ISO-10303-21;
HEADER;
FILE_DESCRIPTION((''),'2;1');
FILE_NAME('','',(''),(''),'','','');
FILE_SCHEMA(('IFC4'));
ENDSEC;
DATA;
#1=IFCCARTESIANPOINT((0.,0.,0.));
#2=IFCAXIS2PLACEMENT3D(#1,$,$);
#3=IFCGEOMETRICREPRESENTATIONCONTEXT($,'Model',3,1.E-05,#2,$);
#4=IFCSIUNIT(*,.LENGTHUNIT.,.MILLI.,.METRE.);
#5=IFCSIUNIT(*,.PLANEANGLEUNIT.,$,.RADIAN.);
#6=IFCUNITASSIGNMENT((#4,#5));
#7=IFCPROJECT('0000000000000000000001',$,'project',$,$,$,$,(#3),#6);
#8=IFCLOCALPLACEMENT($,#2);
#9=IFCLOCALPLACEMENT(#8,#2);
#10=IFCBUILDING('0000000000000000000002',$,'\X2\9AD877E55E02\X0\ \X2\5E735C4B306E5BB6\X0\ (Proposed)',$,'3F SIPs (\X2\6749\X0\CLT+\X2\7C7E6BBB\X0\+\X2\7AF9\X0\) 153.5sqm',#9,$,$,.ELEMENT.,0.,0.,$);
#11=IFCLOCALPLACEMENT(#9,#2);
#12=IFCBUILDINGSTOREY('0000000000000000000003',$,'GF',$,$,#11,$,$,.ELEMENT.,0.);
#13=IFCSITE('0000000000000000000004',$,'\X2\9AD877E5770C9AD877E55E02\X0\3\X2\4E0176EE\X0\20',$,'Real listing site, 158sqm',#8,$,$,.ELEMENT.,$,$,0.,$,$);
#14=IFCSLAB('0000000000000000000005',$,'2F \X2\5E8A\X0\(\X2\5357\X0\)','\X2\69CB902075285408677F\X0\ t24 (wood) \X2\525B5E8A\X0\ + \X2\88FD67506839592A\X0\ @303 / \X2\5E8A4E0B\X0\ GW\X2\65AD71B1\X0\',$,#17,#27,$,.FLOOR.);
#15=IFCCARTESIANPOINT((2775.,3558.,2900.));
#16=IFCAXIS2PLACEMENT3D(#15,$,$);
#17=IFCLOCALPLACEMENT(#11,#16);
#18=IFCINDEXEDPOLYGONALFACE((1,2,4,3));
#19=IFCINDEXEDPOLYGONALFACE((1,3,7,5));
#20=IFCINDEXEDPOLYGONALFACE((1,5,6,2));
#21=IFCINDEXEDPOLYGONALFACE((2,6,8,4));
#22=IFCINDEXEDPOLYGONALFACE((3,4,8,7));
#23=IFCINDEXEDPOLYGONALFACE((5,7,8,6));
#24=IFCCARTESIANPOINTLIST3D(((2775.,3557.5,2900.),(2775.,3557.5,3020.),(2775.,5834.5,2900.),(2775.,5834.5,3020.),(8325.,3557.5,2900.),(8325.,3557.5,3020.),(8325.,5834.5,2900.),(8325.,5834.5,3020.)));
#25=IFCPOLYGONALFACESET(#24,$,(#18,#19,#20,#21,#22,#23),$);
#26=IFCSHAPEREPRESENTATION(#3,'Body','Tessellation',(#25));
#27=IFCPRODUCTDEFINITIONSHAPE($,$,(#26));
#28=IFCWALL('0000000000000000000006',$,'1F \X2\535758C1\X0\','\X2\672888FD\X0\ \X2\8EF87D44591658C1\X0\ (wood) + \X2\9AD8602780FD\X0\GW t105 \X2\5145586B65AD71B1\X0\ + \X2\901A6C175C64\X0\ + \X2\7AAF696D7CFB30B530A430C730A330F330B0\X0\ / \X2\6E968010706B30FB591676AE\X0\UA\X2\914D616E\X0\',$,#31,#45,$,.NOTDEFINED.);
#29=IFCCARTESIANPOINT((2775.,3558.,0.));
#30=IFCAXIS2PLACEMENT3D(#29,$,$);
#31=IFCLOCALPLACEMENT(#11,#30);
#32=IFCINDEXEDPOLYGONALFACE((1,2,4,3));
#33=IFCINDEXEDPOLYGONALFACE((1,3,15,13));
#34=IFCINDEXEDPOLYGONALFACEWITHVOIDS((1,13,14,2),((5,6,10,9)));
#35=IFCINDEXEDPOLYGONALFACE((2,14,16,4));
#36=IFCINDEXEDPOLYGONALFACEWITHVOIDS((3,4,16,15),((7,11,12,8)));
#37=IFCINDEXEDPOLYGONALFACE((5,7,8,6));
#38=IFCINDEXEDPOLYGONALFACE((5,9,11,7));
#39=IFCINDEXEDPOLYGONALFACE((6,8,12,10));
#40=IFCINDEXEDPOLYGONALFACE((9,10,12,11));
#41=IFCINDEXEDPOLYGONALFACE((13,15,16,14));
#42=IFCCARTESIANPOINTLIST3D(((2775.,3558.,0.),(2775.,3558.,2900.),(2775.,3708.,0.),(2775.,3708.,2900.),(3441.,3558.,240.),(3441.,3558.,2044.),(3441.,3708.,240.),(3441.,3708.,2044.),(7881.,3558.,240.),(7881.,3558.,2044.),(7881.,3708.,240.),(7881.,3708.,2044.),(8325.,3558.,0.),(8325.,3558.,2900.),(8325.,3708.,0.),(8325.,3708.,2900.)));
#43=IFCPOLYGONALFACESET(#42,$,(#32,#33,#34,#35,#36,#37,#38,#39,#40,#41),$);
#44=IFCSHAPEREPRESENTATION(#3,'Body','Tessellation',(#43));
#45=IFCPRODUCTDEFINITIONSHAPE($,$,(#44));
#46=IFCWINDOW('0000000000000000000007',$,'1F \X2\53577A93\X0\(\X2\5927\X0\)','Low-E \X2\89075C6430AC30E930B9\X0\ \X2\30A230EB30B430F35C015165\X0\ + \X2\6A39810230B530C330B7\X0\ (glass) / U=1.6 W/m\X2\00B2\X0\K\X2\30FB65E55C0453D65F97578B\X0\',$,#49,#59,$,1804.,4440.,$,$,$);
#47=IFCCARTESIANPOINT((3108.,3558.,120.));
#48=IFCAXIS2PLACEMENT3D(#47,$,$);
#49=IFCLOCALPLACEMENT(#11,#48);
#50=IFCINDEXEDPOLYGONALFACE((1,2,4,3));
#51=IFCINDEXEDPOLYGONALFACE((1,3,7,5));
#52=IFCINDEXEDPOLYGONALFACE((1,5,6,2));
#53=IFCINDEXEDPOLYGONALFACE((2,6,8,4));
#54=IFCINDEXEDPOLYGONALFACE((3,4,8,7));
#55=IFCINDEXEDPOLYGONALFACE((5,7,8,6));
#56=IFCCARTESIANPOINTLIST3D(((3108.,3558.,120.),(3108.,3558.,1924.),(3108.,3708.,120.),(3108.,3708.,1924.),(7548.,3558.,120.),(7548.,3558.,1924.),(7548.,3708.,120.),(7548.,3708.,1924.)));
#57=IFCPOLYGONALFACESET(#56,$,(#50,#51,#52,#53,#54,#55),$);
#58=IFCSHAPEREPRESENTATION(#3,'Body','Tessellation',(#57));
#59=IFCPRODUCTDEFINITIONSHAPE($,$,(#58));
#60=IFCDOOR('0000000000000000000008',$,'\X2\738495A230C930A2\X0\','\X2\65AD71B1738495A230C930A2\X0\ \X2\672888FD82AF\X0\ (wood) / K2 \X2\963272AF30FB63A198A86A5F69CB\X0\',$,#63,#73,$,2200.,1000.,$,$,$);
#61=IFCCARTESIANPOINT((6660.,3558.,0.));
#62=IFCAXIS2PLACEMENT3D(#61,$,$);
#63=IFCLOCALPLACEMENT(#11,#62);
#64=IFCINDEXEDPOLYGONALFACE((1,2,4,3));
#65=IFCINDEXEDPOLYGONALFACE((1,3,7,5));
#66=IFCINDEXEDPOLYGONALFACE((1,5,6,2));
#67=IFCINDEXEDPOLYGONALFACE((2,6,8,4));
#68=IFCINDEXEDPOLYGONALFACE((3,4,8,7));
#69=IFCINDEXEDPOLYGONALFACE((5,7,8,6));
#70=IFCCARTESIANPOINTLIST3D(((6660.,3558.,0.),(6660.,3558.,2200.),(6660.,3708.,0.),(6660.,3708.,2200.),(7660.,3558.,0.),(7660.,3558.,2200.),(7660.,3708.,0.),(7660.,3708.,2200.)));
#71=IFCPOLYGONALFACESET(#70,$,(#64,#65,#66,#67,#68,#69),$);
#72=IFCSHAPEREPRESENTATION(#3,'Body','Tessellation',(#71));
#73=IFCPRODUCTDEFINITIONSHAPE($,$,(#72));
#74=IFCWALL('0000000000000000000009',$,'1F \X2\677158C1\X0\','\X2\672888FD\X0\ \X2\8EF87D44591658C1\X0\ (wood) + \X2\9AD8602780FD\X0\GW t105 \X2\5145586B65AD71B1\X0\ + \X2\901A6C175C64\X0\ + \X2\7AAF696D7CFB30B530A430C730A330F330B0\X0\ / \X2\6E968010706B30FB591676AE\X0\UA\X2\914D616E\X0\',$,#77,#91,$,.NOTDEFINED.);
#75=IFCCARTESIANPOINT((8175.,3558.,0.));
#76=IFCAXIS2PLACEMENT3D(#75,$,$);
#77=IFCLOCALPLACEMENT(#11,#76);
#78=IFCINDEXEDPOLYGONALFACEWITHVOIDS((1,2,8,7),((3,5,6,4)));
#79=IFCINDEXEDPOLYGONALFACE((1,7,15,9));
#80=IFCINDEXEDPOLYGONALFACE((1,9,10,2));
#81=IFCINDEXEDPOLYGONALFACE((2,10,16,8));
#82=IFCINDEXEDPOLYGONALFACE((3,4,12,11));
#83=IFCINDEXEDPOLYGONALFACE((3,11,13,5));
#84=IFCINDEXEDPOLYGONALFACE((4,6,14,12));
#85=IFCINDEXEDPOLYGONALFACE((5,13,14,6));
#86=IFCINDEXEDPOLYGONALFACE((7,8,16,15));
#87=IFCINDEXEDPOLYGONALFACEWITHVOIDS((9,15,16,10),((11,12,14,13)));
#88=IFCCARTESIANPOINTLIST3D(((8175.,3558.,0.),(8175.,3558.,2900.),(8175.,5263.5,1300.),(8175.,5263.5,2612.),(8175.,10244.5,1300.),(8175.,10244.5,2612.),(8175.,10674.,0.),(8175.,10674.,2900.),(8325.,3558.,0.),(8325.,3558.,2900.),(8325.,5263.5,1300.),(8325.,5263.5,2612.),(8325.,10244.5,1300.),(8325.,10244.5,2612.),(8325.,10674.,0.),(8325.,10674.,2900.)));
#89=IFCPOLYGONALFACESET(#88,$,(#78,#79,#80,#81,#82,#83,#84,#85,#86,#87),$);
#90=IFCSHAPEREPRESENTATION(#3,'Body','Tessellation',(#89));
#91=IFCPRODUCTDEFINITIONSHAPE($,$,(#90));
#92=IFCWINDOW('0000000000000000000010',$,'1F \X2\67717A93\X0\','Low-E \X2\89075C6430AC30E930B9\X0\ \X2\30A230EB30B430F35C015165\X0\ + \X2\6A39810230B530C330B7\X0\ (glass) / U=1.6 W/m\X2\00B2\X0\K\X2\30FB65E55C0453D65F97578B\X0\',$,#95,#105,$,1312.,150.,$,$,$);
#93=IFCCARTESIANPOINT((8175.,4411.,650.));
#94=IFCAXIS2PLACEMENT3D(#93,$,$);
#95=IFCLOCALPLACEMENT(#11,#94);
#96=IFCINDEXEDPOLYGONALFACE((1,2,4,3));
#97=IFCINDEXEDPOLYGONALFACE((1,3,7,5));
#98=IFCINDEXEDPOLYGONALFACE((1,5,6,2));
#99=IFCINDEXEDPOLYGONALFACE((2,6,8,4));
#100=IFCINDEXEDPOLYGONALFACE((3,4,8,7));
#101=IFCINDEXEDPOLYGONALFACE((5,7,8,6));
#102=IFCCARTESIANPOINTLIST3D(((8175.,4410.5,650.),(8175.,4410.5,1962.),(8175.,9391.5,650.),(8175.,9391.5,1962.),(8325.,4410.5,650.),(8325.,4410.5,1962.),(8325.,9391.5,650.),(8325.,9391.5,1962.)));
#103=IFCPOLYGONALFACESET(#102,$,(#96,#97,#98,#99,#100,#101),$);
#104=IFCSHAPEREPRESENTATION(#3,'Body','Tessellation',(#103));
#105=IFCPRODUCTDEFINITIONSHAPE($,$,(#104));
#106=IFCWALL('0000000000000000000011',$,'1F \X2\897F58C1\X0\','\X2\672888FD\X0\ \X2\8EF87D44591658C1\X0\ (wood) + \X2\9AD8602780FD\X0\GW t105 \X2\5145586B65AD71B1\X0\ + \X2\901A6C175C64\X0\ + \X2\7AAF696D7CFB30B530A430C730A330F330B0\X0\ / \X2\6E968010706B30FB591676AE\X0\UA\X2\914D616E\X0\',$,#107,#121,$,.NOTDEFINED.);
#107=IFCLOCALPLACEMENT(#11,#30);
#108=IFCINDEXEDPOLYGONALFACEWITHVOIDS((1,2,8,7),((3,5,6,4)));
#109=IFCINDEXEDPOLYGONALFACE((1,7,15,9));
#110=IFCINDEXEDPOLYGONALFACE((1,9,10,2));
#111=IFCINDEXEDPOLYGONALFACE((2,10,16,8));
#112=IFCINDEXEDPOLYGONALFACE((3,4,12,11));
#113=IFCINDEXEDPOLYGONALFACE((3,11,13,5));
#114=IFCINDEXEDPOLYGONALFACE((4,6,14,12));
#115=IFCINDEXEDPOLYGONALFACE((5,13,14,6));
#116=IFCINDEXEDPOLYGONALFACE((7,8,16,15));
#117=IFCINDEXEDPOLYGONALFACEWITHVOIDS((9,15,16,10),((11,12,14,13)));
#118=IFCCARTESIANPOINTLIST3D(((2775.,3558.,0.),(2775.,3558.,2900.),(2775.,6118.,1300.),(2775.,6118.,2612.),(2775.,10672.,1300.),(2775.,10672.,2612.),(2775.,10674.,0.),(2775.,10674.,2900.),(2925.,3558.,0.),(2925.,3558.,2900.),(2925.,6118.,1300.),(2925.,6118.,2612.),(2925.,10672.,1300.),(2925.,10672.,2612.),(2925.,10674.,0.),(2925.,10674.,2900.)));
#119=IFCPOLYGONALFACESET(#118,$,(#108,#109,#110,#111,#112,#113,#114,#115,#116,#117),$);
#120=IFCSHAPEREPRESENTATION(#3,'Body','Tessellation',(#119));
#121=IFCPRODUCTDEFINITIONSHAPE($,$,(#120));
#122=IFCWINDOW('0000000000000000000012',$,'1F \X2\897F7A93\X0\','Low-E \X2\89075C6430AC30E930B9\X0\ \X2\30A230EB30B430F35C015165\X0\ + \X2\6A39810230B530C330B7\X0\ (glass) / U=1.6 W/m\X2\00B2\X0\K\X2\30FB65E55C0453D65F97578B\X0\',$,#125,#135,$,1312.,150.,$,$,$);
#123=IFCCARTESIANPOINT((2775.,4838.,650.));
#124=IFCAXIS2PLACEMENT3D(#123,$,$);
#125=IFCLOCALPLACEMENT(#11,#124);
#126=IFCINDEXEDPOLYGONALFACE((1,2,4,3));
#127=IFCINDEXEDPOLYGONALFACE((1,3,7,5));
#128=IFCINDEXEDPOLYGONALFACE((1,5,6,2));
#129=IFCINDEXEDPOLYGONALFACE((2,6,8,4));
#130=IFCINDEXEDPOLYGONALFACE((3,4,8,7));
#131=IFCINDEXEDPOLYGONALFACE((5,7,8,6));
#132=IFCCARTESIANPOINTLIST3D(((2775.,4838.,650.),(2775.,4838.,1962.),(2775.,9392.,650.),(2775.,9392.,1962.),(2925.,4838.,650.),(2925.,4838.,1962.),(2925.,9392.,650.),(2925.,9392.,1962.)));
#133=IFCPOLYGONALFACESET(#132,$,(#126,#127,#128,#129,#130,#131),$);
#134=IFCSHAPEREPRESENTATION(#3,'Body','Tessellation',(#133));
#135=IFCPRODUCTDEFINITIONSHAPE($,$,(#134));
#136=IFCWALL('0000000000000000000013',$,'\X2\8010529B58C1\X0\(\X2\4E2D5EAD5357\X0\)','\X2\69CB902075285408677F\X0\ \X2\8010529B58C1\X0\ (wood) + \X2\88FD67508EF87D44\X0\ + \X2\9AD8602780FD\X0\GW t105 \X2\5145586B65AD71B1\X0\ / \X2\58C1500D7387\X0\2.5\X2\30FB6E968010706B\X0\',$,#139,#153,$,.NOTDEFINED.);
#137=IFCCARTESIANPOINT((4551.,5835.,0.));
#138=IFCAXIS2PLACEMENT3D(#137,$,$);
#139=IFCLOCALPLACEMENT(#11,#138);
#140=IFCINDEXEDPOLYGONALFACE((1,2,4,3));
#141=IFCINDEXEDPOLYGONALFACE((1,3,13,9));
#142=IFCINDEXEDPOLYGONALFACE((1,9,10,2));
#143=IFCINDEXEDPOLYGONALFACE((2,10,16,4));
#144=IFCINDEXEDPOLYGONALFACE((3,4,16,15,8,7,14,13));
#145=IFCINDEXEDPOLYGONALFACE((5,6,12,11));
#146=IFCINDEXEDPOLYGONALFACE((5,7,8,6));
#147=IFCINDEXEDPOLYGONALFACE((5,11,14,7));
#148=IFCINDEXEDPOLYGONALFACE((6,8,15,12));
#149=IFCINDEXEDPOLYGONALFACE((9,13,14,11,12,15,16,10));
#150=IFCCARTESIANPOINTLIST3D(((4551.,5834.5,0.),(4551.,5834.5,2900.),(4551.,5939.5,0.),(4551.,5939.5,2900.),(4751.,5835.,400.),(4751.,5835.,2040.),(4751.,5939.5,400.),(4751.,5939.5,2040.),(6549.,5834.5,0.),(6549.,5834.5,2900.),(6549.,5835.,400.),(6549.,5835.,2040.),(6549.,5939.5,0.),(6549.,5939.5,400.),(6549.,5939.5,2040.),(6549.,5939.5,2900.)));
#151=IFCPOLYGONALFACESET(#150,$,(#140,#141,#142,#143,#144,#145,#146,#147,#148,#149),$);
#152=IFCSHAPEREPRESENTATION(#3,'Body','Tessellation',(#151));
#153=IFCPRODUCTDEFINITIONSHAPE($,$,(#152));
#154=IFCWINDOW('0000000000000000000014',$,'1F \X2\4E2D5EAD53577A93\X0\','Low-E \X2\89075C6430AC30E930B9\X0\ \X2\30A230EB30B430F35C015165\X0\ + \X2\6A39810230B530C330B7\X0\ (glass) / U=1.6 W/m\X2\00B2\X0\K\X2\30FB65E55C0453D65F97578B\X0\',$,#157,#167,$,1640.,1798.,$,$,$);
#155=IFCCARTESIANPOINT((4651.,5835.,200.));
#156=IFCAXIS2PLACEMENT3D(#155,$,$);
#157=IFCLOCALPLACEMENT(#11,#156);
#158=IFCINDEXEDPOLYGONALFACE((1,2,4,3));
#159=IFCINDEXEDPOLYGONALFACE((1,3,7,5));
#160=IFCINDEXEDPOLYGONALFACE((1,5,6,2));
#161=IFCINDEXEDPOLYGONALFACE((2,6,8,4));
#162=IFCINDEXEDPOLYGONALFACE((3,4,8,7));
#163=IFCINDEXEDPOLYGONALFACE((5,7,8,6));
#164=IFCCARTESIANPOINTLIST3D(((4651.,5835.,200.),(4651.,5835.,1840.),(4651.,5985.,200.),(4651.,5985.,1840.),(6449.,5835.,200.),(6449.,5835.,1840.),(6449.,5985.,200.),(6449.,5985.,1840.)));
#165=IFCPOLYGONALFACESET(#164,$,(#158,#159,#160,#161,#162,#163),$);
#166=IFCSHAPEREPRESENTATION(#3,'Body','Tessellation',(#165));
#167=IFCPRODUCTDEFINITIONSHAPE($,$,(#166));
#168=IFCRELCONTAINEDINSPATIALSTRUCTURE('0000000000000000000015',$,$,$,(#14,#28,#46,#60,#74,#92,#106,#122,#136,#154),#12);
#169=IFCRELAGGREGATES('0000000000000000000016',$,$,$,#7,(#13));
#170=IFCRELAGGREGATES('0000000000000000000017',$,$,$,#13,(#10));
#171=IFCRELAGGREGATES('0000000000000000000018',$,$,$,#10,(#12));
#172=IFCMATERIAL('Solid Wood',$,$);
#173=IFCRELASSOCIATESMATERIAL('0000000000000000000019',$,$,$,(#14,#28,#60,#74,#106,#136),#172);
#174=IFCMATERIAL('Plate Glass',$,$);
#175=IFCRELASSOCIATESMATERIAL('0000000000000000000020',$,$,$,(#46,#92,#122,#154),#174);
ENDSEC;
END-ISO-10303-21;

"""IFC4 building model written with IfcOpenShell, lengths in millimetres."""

from ifc_helpers import new_model, si_unit, frame, frame_2d, origin, place, context, project, spatial, rectangle, extrude, material, element, fill, save


model = new_model("IFC4")

# Units and contexts
model_context = context("Model", 3, precision=1e-05, world=origin())
ifc_project = project(units=[si_unit("LENGTHUNIT", "METRE", prefix="MILLI"), si_unit("PLANEANGLEUNIT", "RADIAN")], contexts=[model_context])

# Site, building, storey
site_placement = place(None, origin())
site = spatial("IfcSite", under=ifc_project, at=site_placement, Name="高知県高知市3丁目20", ObjectType="Real listing site, 158sqm", CompositionType="ELEMENT", RefElevation=0.0)
building_placement = place(site_placement, origin())
building = spatial("IfcBuilding", under=site, at=building_placement, Name="高知市 平屋の家 (Proposed)", ObjectType="3F SIPs (杉CLT+籾殻+竹) 153.5sqm", CompositionType="ELEMENT", ElevationOfRefHeight=0.0, ElevationOfTerrain=0.0)
storey_placement = place(building_placement, origin())
storey = spatial("IfcBuildingStorey", under=building, at=storey_placement, Name="GF", CompositionType="ELEMENT", Elevation=0.0)

# Slab
ifc_material_1 = material(Name="Solid Wood")
slab_1_placement = place(storey_placement, frame((2775.0, 3558.0, 2900.0)))
element("IfcSlab", 1, at=slab_1_placement, inside=storey, material=ifc_material_1, Name="2F 床(南)", Description="構造用合板 t24 (wood) 剛床 + 製材根太 @303 / 床下 GW断熱", PredefinedType="FLOOR", context=model_context, shape_type="SweptSolid", body=[
    extrude(rectangle(XDim=5550.0, YDim=2277.0, at=frame_2d((2775.0, 1138.0))), frame((2775.0, 3558.0, 2900.0)), (0.0, 0.0, 1.0), 120.0),
])

# Wall, openings, window, door
wall_1_placement = place(storey_placement, frame((2775.0, 3558.0, 0.0)))
wall_1 = element("IfcWall", 2, at=wall_1_placement, inside=storey, material=ifc_material_1, Name="1F 南壁", Description="木製 軸組外壁 (wood) + 高性能GW t105 充填断熱 + 通気層 + 窯業系サイディング / 準耐火・外皮UA配慮", PredefinedType="NOTDEFINED", context=model_context, shape_type="SweptSolid", body=[
    extrude(rectangle(XDim=5550.0, YDim=150.0, at=frame_2d((2775.0, 75.0))), frame((2775.0, 3558.0, 0.0)), (0.0, 0.0, 1.0), 2900.0),
])
opening_1_placement = place(storey_placement, frame((3108.0, 3558.0, 120.0)))
opening_1 = element("IfcOpeningElement", 3, at=opening_1_placement, cuts=wall_1, PredefinedType="NOTDEFINED", context=model_context, shape_type="SweptSolid", body=[
    extrude(rectangle(XDim=4440.0, YDim=150.0, at=frame_2d((2220.0, 75.0))), frame((3108.0, 3558.0, 120.0)), (0.0, 0.0, 1.0), 1804.0),
])
opening_2_placement = place(storey_placement, frame((6660.0, 3558.0, 0.0)))
opening_2 = element("IfcOpeningElement", 4, at=opening_2_placement, cuts=wall_1, PredefinedType="NOTDEFINED", context=model_context, shape_type="SweptSolid", body=[
    extrude(rectangle(XDim=1000.0, YDim=150.0, at=frame_2d((500.0, 75.0))), frame((6660.0, 3558.0, 0.0)), (0.0, 0.0, 1.0), 2200.0),
])
ifc_material_2 = material(Name="Plate Glass")
window_1_placement = place(storey_placement, frame((3108.0, 3558.0, 120.0)))
window_1 = element("IfcWindow", 5, at=window_1_placement, inside=storey, material=ifc_material_2, Name="1F 南窓(大)", Description="Low-E 複層ガラス アルゴン封入 + 樹脂サッシ (glass) / U=1.6 W/m²K・日射取得型", OverallHeight=1804.0, OverallWidth=4440.0, context=model_context, shape_type="SweptSolid", body=[
    extrude(rectangle(XDim=4440.0, YDim=150.0, at=frame_2d((2220.0, 75.0))), frame((3108.0, 3558.0, 120.0)), (0.0, 0.0, 1.0), 1804.0),
])
fill(opening_1, window_1)
door_placement = place(storey_placement, frame((6660.0, 3558.0, 0.0)))
door = element("IfcDoor", 6, at=door_placement, inside=storey, material=ifc_material_1, Name="玄関ドア", Description="断熱玄関ドア 木製芯 (wood) / K2 防犯・採風機構", OverallHeight=2200.0, OverallWidth=1000.0, context=model_context, shape_type="SweptSolid", body=[
    extrude(rectangle(XDim=1000.0, YDim=150.0, at=frame_2d((500.0, 75.0))), frame((6660.0, 3558.0, 0.0)), (0.0, 0.0, 1.0), 2200.0),
])
fill(opening_2, door)

# Walls, openings, windows
wall_2_placement = place(storey_placement, frame((8175.0, 3558.0, 0.0)))
wall_2 = element("IfcWall", 7, at=wall_2_placement, inside=storey, material=ifc_material_1, Name="1F 東壁", Description="木製 軸組外壁 (wood) + 高性能GW t105 充填断熱 + 通気層 + 窯業系サイディング / 準耐火・外皮UA配慮", PredefinedType="NOTDEFINED", context=model_context, shape_type="SweptSolid", body=[
    extrude(rectangle(XDim=150.0, YDim=7116.0, at=frame_2d((75.0, 3558.0))), frame((8175.0, 3558.0, 0.0)), (0.0, 0.0, 1.0), 2900.0),
])
opening_3_placement = place(storey_placement, frame((8175.0, 4411.0, 650.0)))
opening_3 = element("IfcOpeningElement", 8, at=opening_3_placement, cuts=wall_2, PredefinedType="NOTDEFINED", context=model_context, shape_type="SweptSolid", body=[
    extrude(rectangle(XDim=150.0, YDim=4981.0, at=frame_2d((75.0, 2490.0))), frame((8175.0, 4411.0, 650.0)), (0.0, 0.0, 1.0), 1312.0),
])
window_2_placement = place(storey_placement, frame((8175.0, 4411.0, 650.0)))
window_2 = element("IfcWindow", 9, at=window_2_placement, inside=storey, material=ifc_material_2, Name="1F 東窓", Description="Low-E 複層ガラス アルゴン封入 + 樹脂サッシ (glass) / U=1.6 W/m²K・日射取得型", OverallHeight=1312.0, OverallWidth=150.0, context=model_context, shape_type="SweptSolid", body=[
    extrude(rectangle(XDim=150.0, YDim=4981.0, at=frame_2d((75.0, 2490.0))), frame((8175.0, 4411.0, 650.0)), (0.0, 0.0, 1.0), 1312.0),
])
fill(opening_3, window_2)
wall_3_placement = place(storey_placement, frame((2775.0, 3558.0, 0.0)))
wall_3 = element("IfcWall", 10, at=wall_3_placement, inside=storey, material=ifc_material_1, Name="1F 西壁", Description="木製 軸組外壁 (wood) + 高性能GW t105 充填断熱 + 通気層 + 窯業系サイディング / 準耐火・外皮UA配慮", PredefinedType="NOTDEFINED", context=model_context, shape_type="SweptSolid", body=[
    extrude(rectangle(XDim=150.0, YDim=7116.0, at=frame_2d((75.0, 3558.0))), frame((2775.0, 3558.0, 0.0)), (0.0, 0.0, 1.0), 2900.0),
])
opening_4_placement = place(storey_placement, frame((2775.0, 4838.0, 650.0)))
opening_4 = element("IfcOpeningElement", 11, at=opening_4_placement, cuts=wall_3, PredefinedType="NOTDEFINED", context=model_context, shape_type="SweptSolid", body=[
    extrude(rectangle(XDim=150.0, YDim=4554.0, at=frame_2d((75.0, 2277.0))), frame((2775.0, 4838.0, 650.0)), (0.0, 0.0, 1.0), 1312.0),
])
window_3_placement = place(storey_placement, frame((2775.0, 4838.0, 650.0)))
window_3 = element("IfcWindow", 12, at=window_3_placement, inside=storey, material=ifc_material_2, Name="1F 西窓", Description="Low-E 複層ガラス アルゴン封入 + 樹脂サッシ (glass) / U=1.6 W/m²K・日射取得型", OverallHeight=1312.0, OverallWidth=150.0, context=model_context, shape_type="SweptSolid", body=[
    extrude(rectangle(XDim=150.0, YDim=4554.0, at=frame_2d((75.0, 2277.0))), frame((2775.0, 4838.0, 650.0)), (0.0, 0.0, 1.0), 1312.0),
])
fill(opening_4, window_3)
wall_4_placement = place(storey_placement, frame((4551.0, 5835.0, 0.0)))
wall_4 = element("IfcWall", 13, at=wall_4_placement, inside=storey, material=ifc_material_1, Name="耐力壁(中庭南)", Description="構造用合板 耐力壁 (wood) + 製材軸組 + 高性能GW t105 充填断熱 / 壁倍率2.5・準耐火", PredefinedType="NOTDEFINED", context=model_context, shape_type="SweptSolid", body=[
    extrude(rectangle(XDim=1998.0, YDim=105.0, at=frame_2d((999.0, 52.0))), frame((4551.0, 5835.0, 0.0)), (0.0, 0.0, 1.0), 2900.0),
])
opening_5_placement = place(storey_placement, frame((4651.0, 5835.0, 200.0)))
opening_5 = element("IfcOpeningElement", 14, at=opening_5_placement, cuts=wall_4, PredefinedType="NOTDEFINED", context=model_context, shape_type="SweptSolid", body=[
    extrude(rectangle(XDim=1798.0, YDim=150.0, at=frame_2d((899.0, 75.0))), frame((4651.0, 5835.0, 200.0)), (0.0, 0.0, 1.0), 1640.0),
])
window_4_placement = place(storey_placement, frame((4651.0, 5835.0, 200.0)))
window_4 = element("IfcWindow", 15, at=window_4_placement, inside=storey, material=ifc_material_2, Name="1F 中庭南窓", Description="Low-E 複層ガラス アルゴン封入 + 樹脂サッシ (glass) / U=1.6 W/m²K・日射取得型", OverallHeight=1640.0, OverallWidth=1798.0, context=model_context, shape_type="SweptSolid", body=[
    extrude(rectangle(XDim=1798.0, YDim=150.0, at=frame_2d((899.0, 75.0))), frame((4651.0, 5835.0, 200.0)), (0.0, 0.0, 1.0), 1640.0),
])
fill(opening_5, window_4)

save(model, "model.ifc")
